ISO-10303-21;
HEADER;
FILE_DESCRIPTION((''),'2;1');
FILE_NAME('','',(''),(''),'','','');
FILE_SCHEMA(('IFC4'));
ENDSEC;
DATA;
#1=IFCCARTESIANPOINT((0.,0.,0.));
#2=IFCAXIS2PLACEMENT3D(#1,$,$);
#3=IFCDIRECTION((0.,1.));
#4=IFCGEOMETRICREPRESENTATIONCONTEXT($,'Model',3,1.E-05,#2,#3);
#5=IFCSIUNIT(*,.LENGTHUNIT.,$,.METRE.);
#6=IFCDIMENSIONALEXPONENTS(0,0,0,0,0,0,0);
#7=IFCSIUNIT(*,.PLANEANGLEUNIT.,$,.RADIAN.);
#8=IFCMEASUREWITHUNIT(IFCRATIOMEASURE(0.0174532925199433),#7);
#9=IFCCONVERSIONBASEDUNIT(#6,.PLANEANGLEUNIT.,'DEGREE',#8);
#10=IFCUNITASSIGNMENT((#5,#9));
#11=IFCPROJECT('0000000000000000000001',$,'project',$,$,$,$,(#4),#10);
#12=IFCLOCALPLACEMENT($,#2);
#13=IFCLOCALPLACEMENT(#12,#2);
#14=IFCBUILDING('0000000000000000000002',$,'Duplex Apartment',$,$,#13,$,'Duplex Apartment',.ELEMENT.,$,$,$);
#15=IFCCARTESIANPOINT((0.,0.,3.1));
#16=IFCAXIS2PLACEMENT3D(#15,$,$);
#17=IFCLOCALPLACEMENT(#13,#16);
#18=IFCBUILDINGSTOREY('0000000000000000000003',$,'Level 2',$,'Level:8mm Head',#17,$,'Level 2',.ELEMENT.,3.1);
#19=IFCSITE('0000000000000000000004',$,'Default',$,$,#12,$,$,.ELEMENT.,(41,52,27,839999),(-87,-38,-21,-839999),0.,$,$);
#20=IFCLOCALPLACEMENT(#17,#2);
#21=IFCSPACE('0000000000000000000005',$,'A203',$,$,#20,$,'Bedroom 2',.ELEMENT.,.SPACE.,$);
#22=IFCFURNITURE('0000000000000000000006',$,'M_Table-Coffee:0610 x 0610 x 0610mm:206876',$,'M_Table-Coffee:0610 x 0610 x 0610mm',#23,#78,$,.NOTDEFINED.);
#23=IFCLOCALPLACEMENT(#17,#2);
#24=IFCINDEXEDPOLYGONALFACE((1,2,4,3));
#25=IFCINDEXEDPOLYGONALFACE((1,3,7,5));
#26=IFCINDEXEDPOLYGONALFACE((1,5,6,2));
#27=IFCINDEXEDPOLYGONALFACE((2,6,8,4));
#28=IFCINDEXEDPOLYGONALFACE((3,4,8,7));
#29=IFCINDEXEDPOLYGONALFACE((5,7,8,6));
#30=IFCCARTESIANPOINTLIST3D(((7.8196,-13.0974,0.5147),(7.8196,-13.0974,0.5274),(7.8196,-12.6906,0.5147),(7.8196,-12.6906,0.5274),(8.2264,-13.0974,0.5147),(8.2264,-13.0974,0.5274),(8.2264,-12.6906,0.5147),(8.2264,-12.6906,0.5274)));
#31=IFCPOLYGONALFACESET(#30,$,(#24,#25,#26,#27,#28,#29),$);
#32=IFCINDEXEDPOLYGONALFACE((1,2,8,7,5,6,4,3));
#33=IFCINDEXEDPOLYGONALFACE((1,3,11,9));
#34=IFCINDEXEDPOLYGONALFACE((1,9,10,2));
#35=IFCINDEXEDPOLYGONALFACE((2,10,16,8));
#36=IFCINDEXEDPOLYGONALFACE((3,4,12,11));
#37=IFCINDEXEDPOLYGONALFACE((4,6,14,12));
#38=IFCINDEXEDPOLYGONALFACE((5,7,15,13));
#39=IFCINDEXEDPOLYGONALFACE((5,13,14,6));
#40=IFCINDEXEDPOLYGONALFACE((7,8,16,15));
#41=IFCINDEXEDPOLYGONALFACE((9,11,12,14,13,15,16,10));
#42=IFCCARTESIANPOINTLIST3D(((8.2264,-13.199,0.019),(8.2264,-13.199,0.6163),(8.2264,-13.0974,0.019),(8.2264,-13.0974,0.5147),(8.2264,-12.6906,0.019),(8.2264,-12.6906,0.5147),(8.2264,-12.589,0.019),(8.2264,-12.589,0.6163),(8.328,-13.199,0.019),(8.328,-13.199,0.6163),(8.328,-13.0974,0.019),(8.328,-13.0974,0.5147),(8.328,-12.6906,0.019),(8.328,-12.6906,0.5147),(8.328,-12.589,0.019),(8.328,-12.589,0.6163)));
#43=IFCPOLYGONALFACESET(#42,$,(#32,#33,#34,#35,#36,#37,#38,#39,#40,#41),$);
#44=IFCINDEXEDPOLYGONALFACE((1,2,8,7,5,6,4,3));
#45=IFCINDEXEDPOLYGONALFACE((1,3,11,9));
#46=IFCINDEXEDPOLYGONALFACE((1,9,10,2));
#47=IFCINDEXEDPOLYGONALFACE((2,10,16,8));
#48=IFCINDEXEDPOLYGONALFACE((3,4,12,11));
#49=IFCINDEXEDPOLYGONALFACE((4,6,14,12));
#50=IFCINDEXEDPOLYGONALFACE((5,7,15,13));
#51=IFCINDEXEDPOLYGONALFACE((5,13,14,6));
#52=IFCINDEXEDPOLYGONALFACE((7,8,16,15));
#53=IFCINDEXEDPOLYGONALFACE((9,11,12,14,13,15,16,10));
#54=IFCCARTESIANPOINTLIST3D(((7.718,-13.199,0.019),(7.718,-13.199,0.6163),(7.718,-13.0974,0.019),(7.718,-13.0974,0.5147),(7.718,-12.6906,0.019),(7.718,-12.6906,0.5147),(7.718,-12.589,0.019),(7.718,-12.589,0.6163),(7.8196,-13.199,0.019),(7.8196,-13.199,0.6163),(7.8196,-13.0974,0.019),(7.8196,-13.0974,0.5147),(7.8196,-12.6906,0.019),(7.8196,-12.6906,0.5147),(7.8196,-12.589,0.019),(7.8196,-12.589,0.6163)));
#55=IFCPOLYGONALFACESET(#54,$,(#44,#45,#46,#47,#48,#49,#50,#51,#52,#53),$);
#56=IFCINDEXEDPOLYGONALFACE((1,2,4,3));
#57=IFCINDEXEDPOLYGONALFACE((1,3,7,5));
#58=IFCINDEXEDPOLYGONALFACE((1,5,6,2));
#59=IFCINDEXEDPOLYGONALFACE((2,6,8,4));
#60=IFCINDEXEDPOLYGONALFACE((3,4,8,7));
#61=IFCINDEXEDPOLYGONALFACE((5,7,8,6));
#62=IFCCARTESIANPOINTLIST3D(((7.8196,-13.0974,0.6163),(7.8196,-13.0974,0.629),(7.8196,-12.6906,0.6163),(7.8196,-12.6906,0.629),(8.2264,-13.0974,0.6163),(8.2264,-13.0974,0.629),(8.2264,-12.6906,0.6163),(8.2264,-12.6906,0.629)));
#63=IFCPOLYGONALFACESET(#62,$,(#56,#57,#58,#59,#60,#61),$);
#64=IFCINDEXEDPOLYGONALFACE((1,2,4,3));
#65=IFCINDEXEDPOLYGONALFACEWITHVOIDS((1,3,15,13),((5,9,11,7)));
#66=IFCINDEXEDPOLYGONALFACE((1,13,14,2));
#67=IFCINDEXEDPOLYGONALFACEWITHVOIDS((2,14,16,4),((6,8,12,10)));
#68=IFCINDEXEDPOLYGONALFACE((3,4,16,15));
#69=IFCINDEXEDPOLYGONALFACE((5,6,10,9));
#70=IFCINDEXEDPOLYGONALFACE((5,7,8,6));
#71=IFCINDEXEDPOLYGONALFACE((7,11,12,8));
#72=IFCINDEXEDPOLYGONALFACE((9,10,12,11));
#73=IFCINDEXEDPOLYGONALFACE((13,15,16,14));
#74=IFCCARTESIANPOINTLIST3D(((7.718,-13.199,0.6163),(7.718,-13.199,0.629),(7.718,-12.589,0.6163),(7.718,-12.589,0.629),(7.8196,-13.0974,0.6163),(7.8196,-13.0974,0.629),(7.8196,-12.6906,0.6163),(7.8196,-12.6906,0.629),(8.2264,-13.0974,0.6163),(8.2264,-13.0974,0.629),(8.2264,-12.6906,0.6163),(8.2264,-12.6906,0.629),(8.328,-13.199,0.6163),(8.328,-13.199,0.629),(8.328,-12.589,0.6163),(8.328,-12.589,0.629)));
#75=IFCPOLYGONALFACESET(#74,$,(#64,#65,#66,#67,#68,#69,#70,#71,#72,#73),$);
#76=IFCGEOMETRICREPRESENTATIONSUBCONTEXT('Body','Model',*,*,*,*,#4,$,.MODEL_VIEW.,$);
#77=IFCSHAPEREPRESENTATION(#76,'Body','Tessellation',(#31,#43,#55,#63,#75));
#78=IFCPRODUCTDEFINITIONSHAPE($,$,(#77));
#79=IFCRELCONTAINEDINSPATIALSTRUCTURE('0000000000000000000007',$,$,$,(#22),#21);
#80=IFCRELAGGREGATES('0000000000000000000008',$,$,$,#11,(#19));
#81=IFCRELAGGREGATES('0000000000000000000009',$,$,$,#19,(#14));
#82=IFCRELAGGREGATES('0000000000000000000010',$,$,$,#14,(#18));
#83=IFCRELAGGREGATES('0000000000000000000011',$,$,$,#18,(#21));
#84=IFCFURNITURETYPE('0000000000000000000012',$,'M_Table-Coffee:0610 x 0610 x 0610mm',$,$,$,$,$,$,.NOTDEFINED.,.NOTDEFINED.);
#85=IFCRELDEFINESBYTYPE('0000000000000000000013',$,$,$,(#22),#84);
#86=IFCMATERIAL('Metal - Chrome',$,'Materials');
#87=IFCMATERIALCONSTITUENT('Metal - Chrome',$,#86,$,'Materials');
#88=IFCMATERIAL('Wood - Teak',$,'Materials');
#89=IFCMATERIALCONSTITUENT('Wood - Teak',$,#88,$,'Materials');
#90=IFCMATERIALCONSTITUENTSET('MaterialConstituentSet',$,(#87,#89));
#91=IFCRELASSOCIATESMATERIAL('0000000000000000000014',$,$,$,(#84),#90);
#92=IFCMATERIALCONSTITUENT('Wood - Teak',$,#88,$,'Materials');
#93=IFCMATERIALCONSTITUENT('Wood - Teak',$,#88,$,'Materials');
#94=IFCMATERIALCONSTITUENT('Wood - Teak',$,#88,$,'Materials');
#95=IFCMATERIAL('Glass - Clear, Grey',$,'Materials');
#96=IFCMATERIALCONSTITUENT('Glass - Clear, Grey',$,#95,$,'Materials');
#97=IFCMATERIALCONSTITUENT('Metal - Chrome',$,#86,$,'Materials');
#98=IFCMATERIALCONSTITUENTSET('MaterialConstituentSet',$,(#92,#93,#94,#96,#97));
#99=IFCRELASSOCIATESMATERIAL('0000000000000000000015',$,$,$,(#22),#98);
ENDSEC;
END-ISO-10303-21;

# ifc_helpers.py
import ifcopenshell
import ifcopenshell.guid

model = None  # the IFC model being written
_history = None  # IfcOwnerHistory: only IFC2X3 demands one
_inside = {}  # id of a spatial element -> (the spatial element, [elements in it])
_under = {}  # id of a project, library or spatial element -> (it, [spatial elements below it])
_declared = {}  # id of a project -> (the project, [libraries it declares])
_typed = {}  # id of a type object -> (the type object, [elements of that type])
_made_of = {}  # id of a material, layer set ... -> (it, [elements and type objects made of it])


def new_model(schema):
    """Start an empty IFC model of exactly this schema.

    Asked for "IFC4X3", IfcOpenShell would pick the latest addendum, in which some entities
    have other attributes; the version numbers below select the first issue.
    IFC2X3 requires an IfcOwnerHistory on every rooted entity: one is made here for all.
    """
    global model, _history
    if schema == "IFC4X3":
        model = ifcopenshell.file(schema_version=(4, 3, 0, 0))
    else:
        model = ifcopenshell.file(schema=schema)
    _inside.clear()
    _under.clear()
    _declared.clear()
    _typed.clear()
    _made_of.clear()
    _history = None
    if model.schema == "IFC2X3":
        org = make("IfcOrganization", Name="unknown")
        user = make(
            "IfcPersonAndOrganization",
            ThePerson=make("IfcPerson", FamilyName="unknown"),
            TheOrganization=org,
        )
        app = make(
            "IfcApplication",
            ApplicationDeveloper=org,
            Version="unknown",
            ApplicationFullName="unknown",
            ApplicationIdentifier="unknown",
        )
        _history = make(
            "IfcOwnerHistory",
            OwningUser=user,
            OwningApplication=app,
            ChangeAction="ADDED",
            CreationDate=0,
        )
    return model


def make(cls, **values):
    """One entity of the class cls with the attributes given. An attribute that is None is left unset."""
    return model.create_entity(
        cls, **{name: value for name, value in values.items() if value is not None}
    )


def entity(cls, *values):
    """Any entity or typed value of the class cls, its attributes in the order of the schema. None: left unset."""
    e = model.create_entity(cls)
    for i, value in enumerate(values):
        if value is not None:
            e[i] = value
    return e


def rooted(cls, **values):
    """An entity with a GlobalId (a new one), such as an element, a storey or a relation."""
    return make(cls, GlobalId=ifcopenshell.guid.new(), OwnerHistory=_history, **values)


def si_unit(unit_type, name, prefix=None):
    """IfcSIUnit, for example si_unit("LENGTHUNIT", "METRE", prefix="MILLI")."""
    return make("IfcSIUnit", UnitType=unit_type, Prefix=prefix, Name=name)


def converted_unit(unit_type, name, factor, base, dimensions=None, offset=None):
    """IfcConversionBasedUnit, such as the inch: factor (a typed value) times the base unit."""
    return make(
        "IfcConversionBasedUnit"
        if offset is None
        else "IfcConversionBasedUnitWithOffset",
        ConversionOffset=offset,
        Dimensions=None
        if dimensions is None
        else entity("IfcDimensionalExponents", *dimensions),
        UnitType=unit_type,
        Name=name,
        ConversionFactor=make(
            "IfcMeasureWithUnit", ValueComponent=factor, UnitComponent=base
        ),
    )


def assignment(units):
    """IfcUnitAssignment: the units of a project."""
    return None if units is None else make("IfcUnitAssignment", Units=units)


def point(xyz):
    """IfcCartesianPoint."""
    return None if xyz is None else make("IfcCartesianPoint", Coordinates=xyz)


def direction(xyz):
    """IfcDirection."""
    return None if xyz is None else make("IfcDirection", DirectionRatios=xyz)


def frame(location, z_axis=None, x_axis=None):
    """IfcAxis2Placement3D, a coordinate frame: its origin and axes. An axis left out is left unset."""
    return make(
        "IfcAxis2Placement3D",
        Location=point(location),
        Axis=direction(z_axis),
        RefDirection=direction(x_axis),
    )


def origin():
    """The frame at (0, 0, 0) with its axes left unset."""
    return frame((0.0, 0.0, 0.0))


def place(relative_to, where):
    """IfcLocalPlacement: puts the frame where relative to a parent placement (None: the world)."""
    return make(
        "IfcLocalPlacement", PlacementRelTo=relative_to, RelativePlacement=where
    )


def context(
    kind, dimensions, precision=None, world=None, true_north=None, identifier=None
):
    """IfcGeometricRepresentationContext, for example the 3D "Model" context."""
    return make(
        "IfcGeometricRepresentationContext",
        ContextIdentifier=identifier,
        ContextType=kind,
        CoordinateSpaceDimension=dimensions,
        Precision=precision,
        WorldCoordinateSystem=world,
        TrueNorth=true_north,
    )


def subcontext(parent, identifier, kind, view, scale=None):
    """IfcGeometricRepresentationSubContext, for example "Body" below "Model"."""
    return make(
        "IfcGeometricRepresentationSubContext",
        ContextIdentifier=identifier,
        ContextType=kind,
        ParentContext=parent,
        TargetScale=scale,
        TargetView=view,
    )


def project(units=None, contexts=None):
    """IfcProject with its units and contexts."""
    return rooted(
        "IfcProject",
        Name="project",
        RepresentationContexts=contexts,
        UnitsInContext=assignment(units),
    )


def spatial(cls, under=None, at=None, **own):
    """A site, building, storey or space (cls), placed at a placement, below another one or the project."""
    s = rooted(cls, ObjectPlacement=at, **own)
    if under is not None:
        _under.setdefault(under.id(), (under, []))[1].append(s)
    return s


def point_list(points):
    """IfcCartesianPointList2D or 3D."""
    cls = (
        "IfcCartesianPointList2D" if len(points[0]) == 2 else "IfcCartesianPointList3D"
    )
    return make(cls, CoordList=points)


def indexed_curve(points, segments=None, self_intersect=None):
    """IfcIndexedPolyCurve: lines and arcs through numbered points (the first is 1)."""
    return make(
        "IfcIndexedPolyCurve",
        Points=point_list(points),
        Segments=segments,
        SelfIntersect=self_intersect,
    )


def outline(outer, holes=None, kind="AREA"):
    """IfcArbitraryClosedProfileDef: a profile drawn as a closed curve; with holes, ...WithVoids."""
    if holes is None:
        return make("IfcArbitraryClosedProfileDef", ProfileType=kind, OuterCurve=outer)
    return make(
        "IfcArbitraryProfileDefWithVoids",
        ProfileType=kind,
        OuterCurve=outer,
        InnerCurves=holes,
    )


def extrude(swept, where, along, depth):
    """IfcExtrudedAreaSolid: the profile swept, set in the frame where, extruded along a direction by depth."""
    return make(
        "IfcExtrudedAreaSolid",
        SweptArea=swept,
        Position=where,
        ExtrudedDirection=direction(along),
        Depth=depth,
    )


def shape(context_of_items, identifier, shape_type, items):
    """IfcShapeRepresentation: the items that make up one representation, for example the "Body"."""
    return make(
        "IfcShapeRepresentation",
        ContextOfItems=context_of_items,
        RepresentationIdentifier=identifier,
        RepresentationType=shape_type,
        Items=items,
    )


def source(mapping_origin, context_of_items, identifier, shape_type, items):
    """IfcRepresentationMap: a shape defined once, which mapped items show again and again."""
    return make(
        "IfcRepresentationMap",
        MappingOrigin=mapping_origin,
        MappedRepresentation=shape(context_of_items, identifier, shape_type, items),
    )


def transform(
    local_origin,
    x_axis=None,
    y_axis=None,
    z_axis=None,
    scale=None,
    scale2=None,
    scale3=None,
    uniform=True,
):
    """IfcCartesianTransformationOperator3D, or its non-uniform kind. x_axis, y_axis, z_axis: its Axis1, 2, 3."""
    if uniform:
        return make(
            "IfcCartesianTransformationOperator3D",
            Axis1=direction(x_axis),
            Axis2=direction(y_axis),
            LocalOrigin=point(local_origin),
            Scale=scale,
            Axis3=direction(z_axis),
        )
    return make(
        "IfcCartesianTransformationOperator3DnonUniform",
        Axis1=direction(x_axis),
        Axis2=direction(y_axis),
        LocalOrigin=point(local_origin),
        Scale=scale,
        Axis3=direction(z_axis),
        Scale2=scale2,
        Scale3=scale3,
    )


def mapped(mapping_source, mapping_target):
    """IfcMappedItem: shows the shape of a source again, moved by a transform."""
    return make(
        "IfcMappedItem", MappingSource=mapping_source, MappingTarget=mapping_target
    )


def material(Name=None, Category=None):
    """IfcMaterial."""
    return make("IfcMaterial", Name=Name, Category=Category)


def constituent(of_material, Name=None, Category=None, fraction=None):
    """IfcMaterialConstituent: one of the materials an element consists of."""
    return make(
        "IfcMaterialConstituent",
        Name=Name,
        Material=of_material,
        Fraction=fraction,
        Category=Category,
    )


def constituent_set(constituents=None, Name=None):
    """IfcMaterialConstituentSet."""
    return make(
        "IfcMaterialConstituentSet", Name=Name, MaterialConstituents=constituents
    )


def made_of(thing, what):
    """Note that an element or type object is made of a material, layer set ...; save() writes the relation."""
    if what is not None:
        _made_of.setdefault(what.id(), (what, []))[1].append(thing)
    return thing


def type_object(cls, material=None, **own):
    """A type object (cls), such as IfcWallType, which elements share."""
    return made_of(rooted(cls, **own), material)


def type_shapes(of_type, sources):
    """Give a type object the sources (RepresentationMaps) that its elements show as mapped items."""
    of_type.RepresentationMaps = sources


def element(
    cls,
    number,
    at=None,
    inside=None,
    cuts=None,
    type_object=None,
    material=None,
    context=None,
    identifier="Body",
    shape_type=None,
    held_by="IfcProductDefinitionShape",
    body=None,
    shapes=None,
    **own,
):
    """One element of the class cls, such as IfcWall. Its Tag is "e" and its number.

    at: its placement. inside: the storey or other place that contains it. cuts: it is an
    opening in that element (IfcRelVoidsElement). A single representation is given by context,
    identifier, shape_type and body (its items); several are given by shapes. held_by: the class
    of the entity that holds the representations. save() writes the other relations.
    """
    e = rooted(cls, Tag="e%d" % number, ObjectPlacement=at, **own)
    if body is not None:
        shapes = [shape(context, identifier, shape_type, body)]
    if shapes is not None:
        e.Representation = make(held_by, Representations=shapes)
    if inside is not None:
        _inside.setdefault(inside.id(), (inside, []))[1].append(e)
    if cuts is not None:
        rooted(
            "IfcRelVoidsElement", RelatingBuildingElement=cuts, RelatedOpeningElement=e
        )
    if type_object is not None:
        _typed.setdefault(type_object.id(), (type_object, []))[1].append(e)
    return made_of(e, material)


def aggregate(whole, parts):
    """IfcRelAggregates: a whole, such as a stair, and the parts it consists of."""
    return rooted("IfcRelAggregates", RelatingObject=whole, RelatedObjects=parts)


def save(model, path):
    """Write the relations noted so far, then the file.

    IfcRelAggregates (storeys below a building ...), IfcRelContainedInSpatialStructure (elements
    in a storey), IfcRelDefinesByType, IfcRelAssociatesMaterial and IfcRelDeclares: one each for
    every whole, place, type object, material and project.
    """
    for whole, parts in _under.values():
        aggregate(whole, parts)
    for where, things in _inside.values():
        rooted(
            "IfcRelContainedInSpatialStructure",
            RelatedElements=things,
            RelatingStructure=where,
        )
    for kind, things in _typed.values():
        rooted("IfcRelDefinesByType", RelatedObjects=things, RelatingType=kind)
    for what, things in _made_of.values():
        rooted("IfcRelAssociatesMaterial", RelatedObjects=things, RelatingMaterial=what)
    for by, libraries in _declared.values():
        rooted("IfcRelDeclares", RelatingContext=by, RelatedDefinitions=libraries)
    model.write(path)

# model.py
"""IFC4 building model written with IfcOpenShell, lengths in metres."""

from ifc_helpers import new_model, entity, si_unit, converted_unit, direction, frame, origin, place, context, subcontext, project, spatial, indexed_curve, outline, extrude, source, transform, mapped, material, constituent, constituent_set, type_object, type_shapes, element, save


model = new_model("IFC4")

# Units and contexts
model_context = context("Model", 3, precision=1e-05, world=origin(), true_north=direction((0.0, 1.0)))
body_context = subcontext(model_context, "Body", "Model", "MODEL_VIEW")
ifc_project = project(units=[si_unit("LENGTHUNIT", "METRE"), converted_unit("PLANEANGLEUNIT", "DEGREE", entity("IfcRatioMeasure", 0.0174532925199433), si_unit("PLANEANGLEUNIT", "RADIAN"), dimensions=[0, 0, 0, 0, 0, 0, 0])], contexts=[model_context])

# Site, building, storey
site_placement = place(None, origin())
site = spatial("IfcSite", under=ifc_project, at=site_placement, Name="Default", CompositionType="ELEMENT", RefLatitude=(41, 52, 27, 839999), RefLongitude=(-87, -38, -21, -839999), RefElevation=0.0)
building_placement = place(site_placement, origin())
building = spatial("IfcBuilding", under=site, at=building_placement, Name="Duplex Apartment", LongName="Duplex Apartment", CompositionType="ELEMENT")
storey_placement = place(building_placement, frame((0.0, 0.0, 3.1)))
storey = spatial("IfcBuildingStorey", under=building, at=storey_placement, Name="Level 2", ObjectType="Level:8mm Head", LongName="Level 2", CompositionType="ELEMENT", Elevation=3.1)

# Shared definitions
space_1_placement = place(storey_placement, origin())
space_1 = spatial("IfcSpace", under=storey, at=space_1_placement, Name="A203", LongName="Bedroom 2", CompositionType="ELEMENT", PredefinedType="SPACE")

# Furniture
ifc_material_1 = material(Name="Wood - Teak", Category="Materials")
ifc_material_2 = material(Name="Glass - Clear, Grey", Category="Materials")
ifc_material_3 = material(Name="Metal - Chrome", Category="Materials")
ifc_constituent_1 = constituent(ifc_material_3, Name="Metal - Chrome", Category="Materials")
ifc_constituent_2 = constituent(ifc_material_1, Name="Wood - Teak", Category="Materials")
ifc_constituent_set_1 = constituent_set(constituents=[ifc_constituent_1, ifc_constituent_2], Name="MaterialConstituentSet")
furniture_type_1 = type_object("IfcFurnitureType", Name="M_Table-Coffee:0610 x 0610 x 0610mm", AssemblyPlace="NOTDEFINED", PredefinedType="NOTDEFINED", material=ifc_constituent_set_1)
shared_shape_1 = source(origin(), body_context, "Body", "SweptSolid", [
    extrude(outline(indexed_curve([(-0.2034, -0.2034), (0.2034, -0.2034), (0.2034, 0.2034), (-0.2034, 0.2034), (-0.2034, -0.2034)], self_intersect=False)), frame((0.0183, 0.0952, 0.4957), z_axis=(0.0, 0.0, 1.0), x_axis=(-1.0, 0.0, 0.0)), (0.0, 0.0, 1.0), 0.0127),
    extrude(outline(indexed_curve([(-0.2732, -0.305), (0.324, -0.305), (0.324, 0.305), (-0.2732, 0.305), (-0.2732, 0.2034), (0.2225, 0.2034), (0.2225, -0.2034), (-0.2732, -0.2034), (-0.2732, -0.305)], self_intersect=False)), frame((0.2217, 0.0952, 0.2732), z_axis=(1.0, 0.0, 0.0), x_axis=(0.0, 0.0, 1.0)), (0.0, 0.0, 1.0), 0.1016),
    extrude(outline(indexed_curve([(-0.305, -0.3241), (0.305, -0.3241), (0.305, 0.2733), (0.2034, 0.2733), (0.2034, -0.2224), (-0.2034, -0.2224), (-0.2034, 0.2733), (-0.305, 0.2733), (-0.305, -0.3241)], self_intersect=False)), frame((-0.2867, 0.0952, 0.2733), z_axis=(1.0, 0.0, 0.0), x_axis=(0.0, -1.0, 0.0)), (0.0, 0.0, 1.0), 0.1016),
    extrude(outline(indexed_curve([(-0.2034, -0.2034), (0.2034, -0.2034), (0.2034, 0.2034), (-0.2034, 0.2034), (-0.2034, -0.2034)], self_intersect=False)), frame((0.0183, 0.0952, 0.5973), z_axis=(0.0, 0.0, 1.0), x_axis=(-1.0, 0.0, 0.0)), (0.0, 0.0, 1.0), 0.0127),
    extrude(outline(indexed_curve([(-0.305, -0.305), (0.305, -0.305), (0.305, 0.305), (-0.305, 0.305), (-0.305, -0.305)], self_intersect=False), holes=[indexed_curve([(-0.2034, -0.2034), (-0.2034, 0.2034), (0.2034, 0.2034), (0.2034, -0.2034), (-0.2034, -0.2034)], self_intersect=False)]), frame((0.0183, 0.0952, 0.5973), z_axis=(0.0, 0.0, 1.0), x_axis=(-1.0, 0.0, 0.0)), (0.0, 0.0, 1.0), 0.0127),
])
type_shapes(furniture_type_1, [shared_shape_1])
ifc_constituent_3 = constituent(ifc_material_1, Name="Wood - Teak", Category="Materials")
ifc_constituent_4 = constituent(ifc_material_1, Name="Wood - Teak", Category="Materials")
ifc_constituent_5 = constituent(ifc_material_1, Name="Wood - Teak", Category="Materials")
ifc_constituent_6 = constituent(ifc_material_2, Name="Glass - Clear, Grey", Category="Materials")
ifc_constituent_7 = constituent(ifc_material_3, Name="Metal - Chrome", Category="Materials")
ifc_constituent_set_2 = constituent_set(constituents=[ifc_constituent_3, ifc_constituent_4, ifc_constituent_5, ifc_constituent_6, ifc_constituent_7], Name="MaterialConstituentSet")
furniture_1_placement = place(space_1_placement, frame((8.0047, -12.9892, 0.019)))
element("IfcFurniture", 1, at=furniture_1_placement, inside=space_1, type_object=furniture_type_1, material=ifc_constituent_set_2, Name="M_Table-Coffee:0610 x 0610 x 0610mm:206876", ObjectType="M_Table-Coffee:0610 x 0610 x 0610mm", PredefinedType="NOTDEFINED", context=body_context, shape_type="MappedRepresentation", body=[
    mapped(shared_shape_1, transform((0.0, 0.0, 0.0), scale=1.0)),
])

save(model, "model.ifc")
